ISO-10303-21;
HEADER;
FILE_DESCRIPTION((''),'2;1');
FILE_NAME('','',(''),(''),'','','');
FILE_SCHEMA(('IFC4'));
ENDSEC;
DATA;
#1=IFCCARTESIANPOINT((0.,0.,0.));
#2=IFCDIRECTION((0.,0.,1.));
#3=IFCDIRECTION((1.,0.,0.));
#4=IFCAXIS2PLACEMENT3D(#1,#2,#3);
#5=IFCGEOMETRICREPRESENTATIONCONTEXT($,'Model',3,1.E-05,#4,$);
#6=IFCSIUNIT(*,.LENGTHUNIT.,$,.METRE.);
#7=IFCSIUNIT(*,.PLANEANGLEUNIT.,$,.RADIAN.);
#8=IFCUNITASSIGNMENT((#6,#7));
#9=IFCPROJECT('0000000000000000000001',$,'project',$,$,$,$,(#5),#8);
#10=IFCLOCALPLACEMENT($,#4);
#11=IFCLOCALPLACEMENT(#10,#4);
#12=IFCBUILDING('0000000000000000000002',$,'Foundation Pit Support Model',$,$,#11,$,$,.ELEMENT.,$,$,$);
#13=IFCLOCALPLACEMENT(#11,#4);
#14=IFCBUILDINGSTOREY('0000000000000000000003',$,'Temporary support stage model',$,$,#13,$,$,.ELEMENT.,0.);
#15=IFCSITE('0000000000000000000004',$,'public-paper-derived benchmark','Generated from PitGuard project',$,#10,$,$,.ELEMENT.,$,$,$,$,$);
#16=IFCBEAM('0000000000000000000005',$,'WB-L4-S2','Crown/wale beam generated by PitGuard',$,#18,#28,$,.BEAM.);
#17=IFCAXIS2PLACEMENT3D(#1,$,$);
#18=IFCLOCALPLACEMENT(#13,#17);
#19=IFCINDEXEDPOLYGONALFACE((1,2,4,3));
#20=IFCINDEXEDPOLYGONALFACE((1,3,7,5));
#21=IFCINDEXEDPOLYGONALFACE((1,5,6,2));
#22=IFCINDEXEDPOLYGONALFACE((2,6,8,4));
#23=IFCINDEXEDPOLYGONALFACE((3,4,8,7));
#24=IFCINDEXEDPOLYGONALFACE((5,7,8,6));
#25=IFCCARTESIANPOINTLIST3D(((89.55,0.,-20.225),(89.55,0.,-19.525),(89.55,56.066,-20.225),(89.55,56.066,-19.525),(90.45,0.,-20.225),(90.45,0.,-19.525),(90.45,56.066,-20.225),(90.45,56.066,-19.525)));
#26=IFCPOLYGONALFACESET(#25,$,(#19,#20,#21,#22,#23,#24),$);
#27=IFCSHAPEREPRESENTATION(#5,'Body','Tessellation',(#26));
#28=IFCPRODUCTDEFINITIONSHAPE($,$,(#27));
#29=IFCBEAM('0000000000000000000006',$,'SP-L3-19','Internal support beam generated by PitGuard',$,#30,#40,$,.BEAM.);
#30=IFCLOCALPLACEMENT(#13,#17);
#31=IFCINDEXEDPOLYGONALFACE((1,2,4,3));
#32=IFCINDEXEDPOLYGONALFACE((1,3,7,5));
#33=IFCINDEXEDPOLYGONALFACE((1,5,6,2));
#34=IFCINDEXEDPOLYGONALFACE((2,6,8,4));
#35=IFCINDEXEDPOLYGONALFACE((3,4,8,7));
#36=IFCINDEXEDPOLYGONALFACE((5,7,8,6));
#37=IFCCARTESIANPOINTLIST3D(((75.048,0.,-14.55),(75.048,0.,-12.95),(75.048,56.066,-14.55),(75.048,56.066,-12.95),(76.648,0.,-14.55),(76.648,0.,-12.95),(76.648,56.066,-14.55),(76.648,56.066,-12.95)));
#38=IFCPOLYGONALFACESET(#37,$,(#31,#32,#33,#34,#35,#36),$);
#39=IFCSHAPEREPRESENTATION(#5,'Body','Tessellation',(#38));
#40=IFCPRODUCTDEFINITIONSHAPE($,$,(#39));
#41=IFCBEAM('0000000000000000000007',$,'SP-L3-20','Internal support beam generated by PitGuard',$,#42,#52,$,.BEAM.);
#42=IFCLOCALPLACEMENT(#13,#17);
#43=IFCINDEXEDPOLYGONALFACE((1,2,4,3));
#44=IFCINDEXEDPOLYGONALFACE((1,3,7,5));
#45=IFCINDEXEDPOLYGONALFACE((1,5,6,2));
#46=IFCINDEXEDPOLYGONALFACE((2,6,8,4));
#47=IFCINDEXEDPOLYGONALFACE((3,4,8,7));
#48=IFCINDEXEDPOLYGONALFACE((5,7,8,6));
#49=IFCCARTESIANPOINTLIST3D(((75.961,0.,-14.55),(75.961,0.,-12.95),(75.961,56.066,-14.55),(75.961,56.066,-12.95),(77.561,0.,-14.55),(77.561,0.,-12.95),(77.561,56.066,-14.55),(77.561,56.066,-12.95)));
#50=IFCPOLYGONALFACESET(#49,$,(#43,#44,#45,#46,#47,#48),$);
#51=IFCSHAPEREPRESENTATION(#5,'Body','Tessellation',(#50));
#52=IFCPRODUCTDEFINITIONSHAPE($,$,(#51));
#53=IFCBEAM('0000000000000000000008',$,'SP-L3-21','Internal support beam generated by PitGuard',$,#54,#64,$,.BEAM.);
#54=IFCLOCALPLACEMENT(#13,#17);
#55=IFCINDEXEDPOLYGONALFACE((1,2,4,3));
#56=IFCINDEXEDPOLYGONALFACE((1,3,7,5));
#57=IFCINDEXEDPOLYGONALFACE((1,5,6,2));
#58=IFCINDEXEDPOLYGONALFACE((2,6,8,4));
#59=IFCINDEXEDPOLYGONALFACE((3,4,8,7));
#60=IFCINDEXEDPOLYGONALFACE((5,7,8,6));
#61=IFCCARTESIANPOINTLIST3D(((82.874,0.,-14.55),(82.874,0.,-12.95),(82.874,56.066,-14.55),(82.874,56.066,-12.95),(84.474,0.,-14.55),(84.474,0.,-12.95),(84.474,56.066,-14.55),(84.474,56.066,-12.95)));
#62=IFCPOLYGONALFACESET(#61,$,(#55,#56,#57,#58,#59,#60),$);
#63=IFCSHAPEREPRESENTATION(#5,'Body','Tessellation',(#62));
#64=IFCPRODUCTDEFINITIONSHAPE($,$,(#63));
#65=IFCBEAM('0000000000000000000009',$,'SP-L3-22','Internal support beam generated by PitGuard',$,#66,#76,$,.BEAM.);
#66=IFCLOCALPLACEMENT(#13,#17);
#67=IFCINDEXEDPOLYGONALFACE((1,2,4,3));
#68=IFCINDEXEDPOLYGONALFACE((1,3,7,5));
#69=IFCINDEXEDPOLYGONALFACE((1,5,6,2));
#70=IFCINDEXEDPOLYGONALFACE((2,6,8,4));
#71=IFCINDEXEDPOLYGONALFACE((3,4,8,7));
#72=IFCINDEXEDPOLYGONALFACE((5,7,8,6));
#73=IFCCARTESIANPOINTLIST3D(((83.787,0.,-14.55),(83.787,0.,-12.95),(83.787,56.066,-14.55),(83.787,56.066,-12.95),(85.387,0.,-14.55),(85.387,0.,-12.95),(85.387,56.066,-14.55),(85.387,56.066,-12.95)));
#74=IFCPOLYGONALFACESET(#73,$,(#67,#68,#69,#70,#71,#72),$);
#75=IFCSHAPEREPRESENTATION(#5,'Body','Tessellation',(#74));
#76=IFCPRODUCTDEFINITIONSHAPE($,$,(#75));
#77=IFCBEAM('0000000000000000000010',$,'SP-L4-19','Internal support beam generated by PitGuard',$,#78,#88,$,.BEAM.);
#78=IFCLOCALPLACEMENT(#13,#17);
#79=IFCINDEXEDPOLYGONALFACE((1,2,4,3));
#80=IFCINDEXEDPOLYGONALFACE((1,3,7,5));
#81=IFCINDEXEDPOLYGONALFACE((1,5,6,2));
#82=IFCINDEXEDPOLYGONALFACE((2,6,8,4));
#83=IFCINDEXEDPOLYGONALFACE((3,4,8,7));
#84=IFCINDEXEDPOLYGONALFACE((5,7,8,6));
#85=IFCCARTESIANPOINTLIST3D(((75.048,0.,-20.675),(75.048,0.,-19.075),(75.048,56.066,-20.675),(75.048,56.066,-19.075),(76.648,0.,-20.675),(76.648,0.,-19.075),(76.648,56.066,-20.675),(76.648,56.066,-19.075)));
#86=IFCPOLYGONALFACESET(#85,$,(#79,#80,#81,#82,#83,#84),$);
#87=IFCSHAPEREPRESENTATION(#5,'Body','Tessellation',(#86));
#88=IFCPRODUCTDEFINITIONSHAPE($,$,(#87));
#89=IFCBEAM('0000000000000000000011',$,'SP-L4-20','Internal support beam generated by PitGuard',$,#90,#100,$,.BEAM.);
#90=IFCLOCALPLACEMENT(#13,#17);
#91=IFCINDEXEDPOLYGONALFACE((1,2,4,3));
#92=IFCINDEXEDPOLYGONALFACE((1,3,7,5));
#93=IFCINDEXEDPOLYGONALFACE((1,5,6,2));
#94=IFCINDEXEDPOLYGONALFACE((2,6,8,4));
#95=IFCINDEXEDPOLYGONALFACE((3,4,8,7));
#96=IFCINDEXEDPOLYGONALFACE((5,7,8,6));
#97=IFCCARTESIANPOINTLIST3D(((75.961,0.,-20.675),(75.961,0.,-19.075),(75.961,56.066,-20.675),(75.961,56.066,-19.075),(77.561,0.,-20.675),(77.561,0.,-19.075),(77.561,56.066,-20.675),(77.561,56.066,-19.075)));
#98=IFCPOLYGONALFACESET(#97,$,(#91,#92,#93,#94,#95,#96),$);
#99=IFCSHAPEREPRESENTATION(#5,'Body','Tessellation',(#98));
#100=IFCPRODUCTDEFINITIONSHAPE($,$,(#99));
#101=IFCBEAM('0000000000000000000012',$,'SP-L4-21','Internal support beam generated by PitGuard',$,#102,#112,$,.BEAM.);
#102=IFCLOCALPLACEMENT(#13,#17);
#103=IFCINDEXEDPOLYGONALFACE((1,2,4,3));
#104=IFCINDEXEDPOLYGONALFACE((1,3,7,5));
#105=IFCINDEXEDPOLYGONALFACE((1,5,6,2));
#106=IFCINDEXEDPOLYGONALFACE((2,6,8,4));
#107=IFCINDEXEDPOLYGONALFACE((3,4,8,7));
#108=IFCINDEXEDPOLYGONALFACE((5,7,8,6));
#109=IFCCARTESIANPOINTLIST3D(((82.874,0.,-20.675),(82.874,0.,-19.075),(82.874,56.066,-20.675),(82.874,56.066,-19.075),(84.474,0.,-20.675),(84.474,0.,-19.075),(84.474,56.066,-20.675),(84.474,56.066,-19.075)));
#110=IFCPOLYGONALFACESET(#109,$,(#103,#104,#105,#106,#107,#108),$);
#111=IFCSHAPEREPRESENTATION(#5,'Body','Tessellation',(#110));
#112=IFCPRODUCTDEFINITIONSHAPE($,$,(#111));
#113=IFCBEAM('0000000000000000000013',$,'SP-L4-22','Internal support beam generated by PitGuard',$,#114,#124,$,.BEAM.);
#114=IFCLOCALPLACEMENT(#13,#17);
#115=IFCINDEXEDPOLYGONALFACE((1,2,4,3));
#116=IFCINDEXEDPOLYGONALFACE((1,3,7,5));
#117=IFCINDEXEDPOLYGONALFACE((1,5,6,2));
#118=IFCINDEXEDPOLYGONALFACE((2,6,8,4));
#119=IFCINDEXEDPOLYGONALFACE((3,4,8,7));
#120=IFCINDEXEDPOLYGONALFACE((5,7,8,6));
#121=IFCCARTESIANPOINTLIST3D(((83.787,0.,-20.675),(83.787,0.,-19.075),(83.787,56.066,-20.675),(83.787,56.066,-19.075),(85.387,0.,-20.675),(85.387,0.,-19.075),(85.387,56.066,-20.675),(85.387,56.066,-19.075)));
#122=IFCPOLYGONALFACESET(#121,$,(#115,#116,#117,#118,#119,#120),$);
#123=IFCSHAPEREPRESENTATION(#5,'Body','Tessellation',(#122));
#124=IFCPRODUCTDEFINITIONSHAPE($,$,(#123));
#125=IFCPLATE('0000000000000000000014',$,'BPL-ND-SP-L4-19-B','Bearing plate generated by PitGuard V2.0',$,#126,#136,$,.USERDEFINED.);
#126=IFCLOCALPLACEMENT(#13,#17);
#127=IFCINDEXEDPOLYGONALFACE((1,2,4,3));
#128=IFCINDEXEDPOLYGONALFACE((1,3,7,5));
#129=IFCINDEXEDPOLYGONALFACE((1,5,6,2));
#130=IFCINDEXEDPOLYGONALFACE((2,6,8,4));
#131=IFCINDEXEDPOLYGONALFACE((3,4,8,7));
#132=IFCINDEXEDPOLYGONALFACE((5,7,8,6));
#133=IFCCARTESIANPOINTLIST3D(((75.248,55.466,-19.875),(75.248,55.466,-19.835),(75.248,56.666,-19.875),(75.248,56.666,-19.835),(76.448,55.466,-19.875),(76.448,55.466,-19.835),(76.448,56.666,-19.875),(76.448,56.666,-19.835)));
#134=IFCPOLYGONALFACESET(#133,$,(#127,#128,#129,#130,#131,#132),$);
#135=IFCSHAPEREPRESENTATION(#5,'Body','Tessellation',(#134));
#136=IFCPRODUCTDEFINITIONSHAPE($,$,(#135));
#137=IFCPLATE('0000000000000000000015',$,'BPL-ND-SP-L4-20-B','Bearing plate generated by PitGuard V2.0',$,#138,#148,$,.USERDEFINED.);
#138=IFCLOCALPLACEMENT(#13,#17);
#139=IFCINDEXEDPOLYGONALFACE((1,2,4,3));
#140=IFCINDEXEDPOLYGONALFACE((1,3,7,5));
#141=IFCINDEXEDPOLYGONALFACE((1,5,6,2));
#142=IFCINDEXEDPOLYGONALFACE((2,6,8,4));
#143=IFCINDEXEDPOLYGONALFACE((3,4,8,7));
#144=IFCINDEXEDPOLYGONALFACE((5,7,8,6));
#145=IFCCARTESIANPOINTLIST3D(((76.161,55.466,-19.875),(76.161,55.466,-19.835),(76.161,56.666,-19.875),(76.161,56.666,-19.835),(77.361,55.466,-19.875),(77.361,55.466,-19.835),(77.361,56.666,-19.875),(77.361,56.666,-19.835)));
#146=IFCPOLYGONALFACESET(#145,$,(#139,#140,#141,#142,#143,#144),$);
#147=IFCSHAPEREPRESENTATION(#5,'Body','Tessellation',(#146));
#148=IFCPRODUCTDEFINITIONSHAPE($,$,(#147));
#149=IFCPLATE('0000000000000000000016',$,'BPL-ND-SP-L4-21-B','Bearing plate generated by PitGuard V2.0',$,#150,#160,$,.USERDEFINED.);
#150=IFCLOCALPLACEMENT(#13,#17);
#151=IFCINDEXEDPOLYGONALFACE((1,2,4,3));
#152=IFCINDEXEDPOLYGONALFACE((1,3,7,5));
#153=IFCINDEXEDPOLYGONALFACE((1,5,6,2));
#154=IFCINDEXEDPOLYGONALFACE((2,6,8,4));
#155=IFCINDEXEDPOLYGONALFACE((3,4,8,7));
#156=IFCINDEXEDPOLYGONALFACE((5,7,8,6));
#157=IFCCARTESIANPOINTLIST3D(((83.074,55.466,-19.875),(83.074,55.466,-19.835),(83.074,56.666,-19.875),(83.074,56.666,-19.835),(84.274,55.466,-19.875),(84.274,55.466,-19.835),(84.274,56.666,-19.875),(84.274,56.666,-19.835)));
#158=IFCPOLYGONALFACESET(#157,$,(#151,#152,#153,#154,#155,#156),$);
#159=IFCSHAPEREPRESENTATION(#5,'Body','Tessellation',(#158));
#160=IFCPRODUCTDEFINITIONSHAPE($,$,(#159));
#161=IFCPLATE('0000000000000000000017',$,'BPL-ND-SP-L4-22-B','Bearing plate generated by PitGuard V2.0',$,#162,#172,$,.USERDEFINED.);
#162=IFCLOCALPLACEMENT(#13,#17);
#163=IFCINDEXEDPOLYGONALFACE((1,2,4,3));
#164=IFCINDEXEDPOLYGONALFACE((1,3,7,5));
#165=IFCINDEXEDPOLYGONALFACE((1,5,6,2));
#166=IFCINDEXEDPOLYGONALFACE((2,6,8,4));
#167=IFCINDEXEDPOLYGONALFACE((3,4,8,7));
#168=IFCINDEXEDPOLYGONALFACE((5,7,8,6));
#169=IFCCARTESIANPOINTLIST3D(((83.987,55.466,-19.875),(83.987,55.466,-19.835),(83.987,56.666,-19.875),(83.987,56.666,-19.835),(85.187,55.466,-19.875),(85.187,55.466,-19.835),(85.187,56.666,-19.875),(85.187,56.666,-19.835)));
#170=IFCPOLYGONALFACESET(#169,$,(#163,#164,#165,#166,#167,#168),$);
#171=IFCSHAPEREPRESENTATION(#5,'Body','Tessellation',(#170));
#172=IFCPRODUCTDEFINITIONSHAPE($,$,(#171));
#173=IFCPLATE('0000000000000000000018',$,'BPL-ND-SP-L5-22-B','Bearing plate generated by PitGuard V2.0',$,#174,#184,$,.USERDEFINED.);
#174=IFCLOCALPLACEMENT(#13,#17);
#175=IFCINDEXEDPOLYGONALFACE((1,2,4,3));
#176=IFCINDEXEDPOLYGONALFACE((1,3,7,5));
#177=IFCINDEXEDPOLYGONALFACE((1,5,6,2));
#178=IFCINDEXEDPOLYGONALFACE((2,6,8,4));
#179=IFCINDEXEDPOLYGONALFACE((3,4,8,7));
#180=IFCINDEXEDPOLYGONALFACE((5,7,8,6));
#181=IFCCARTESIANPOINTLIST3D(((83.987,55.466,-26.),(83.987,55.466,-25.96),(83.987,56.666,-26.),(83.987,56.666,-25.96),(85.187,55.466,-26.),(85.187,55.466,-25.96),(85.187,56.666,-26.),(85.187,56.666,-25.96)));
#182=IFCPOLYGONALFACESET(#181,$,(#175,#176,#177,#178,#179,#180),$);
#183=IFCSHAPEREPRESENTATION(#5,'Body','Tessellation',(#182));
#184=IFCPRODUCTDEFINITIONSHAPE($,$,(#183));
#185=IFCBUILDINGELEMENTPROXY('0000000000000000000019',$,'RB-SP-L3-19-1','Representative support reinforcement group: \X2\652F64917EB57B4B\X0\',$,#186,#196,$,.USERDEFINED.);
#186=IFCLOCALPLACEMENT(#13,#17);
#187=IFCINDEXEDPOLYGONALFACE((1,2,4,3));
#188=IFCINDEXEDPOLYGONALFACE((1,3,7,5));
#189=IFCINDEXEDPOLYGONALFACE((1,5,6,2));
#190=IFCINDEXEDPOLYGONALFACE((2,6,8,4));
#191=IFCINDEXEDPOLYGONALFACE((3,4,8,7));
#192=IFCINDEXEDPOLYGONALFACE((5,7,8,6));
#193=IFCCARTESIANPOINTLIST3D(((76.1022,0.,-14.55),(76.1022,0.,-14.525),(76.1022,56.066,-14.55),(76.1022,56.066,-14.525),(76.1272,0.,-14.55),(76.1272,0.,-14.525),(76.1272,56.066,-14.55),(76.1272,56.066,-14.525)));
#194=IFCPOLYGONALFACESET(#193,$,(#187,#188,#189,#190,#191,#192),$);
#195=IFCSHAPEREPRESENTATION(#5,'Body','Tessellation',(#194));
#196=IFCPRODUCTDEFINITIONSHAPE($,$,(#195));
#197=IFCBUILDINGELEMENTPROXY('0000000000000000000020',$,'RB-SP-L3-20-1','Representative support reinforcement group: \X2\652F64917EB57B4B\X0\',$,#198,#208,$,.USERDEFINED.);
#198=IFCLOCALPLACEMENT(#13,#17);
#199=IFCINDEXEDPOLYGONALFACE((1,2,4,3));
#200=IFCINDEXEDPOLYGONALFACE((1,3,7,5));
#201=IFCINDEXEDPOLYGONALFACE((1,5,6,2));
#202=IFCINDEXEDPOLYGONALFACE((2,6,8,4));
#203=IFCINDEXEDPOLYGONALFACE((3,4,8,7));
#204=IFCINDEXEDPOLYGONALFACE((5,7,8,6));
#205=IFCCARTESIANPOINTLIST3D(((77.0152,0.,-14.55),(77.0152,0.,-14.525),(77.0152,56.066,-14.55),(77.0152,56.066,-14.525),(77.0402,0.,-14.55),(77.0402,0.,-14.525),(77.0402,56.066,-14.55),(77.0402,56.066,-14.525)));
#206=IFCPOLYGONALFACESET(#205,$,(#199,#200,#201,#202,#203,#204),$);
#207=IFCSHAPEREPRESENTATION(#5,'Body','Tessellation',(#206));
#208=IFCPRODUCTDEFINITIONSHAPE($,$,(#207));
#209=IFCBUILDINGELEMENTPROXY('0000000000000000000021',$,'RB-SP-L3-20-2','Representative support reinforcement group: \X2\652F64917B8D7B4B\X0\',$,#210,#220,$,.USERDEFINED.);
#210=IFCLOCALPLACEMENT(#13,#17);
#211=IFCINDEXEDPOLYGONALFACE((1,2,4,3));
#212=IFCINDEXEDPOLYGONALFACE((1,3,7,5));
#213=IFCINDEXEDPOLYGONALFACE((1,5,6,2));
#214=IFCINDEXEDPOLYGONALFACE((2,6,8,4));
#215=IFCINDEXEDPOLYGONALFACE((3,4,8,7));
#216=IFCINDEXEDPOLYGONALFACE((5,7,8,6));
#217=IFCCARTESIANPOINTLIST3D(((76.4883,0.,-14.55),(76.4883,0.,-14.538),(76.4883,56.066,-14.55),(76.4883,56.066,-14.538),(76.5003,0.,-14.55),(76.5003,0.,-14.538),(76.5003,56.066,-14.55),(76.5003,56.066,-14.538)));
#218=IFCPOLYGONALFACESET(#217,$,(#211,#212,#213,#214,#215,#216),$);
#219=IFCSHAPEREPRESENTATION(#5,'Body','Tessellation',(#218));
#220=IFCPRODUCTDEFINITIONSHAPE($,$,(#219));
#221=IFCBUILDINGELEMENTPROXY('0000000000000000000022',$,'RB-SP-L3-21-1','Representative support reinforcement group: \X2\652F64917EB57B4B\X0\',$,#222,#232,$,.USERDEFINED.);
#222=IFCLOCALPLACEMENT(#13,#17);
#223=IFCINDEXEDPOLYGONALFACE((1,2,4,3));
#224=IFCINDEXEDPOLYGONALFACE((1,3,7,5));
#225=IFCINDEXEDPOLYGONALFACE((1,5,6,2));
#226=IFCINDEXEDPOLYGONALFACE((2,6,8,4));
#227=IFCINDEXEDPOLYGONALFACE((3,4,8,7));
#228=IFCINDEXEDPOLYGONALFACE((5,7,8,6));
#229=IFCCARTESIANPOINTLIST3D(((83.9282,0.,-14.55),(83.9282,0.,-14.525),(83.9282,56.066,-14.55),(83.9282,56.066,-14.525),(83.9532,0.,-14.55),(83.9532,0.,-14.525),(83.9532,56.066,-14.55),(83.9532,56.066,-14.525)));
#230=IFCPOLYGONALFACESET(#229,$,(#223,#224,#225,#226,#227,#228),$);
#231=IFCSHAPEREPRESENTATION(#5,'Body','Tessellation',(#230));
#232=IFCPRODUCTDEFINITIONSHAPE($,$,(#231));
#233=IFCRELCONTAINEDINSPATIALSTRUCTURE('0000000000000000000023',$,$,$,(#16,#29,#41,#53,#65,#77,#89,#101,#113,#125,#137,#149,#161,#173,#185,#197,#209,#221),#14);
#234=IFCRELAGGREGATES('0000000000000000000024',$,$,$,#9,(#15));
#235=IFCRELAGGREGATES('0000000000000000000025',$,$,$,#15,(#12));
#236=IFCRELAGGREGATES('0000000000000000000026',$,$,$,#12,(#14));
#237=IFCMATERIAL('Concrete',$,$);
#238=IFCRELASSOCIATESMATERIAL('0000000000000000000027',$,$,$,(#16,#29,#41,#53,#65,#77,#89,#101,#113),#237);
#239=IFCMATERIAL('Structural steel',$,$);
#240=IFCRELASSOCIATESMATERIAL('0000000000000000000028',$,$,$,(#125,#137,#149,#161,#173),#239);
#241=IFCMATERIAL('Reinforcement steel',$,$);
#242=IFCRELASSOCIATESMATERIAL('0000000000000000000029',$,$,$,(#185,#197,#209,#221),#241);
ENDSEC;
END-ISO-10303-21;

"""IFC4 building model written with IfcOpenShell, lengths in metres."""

from ifc_helpers import new_model, si_unit, frame, origin_with_axes, origin_2d, place, context, project, spatial, rectangle, extrude, material, element, save


model = new_model("IFC4")

# Units and contexts
model_context = context("Model", 3, precision=1e-05, world=origin_with_axes())
ifc_project = project(units=[si_unit("LENGTHUNIT", "METRE"), si_unit("PLANEANGLEUNIT", "RADIAN")], contexts=[model_context])

# Site, building, storey
site_placement = place(None, origin_with_axes())
site = spatial("IfcSite", under=ifc_project, at=site_placement, Name="public-paper-derived benchmark", Description="Generated from PitGuard project", CompositionType="ELEMENT")
building_placement = place(site_placement, origin_with_axes())
building = spatial("IfcBuilding", under=site, at=building_placement, Name="Foundation Pit Support Model", CompositionType="ELEMENT")
storey_placement = place(building_placement, origin_with_axes())
storey = spatial("IfcBuildingStorey", under=building, at=storey_placement, Name="Temporary support stage model", CompositionType="ELEMENT", Elevation=0.0)

# Beams
ifc_material_1 = material(Name="Concrete")
beam_placement = place(storey_placement, frame((90.0, 28.033, -20.225), z_axis=(0.0, 0.0, 1.0), x_axis=(0.0, 1.0, 0.0)))
element("IfcBeam", 1, at=beam_placement, inside=storey, material=ifc_material_1, Name="WB-L4-S2", Description="Crown/wale beam generated by PitGuard", PredefinedType="BEAM", context=model_context, shape_type="SweptSolid", body=[
    extrude(rectangle(XDim=56.066, YDim=0.9, at=origin_2d()), origin_with_axes(), (0.0, 0.0, 1.0), 0.7),
])
for number, where, z_axis, x_axis, name in (
    (2, (75.848, 28.033, -14.55), (0.0, 0.0, 1.0), (0.0, 1.0, 0.0), "SP-L3-19"),
    (3, (76.761, 28.033, -14.55), (0.0, 0.0, 1.0), (0.0, 1.0, 0.0), "SP-L3-20"),
    (4, (83.674, 28.033, -14.55), (0.0, 0.0, 1.0), (0.0, 1.0, 0.0), "SP-L3-21"),
    (5, (84.587, 28.033, -14.55), (0.0, 0.0, 1.0), (0.0, 1.0, 0.0), "SP-L3-22"),
    (6, (75.848, 28.033, -20.675), (0.0, 0.0, 1.0), (0.0, 1.0, 0.0), "SP-L4-19"),
    (7, (76.761, 28.033, -20.675), (0.0, 0.0, 1.0), (0.0, 1.0, 0.0), "SP-L4-20"),
    (8, (83.674, 28.033, -20.675), (0.0, 0.0, 1.0), (0.0, 1.0, 0.0), "SP-L4-21"),
    (9, (84.587, 28.033, -20.675), (0.0, 0.0, 1.0), (0.0, 1.0, 0.0), "SP-L4-22"),
):
    element("IfcBeam", number, at=place(storey_placement, frame(where, z_axis=z_axis, x_axis=x_axis)), inside=storey, material=ifc_material_1, Name=name, Description="Internal support beam generated by PitGuard", PredefinedType="BEAM", context=model_context, shape_type="SweptSolid", body=[
        extrude(rectangle(XDim=56.066, YDim=1.6, at=origin_2d()), origin_with_axes(), (0.0, 0.0, 1.0), 1.6),
    ])

# Plates
ifc_material_2 = material(Name="Structural steel")
for number, where, z_axis, x_axis, name in (
    (10, (75.848, 56.066, -19.875), (0.0, 0.0, 1.0), (1.0, 0.0, 0.0), "BPL-ND-SP-L4-19-B"),
    (11, (76.761, 56.066, -19.875), (0.0, 0.0, 1.0), (1.0, 0.0, 0.0), "BPL-ND-SP-L4-20-B"),
    (12, (83.674, 56.066, -19.875), (0.0, 0.0, 1.0), (1.0, 0.0, 0.0), "BPL-ND-SP-L4-21-B"),
    (13, (84.587, 56.066, -19.875), (0.0, 0.0, 1.0), (1.0, 0.0, 0.0), "BPL-ND-SP-L4-22-B"),
    (14, (84.587, 56.066, -26.0), (0.0, 0.0, 1.0), (1.0, 0.0, 0.0), "BPL-ND-SP-L5-22-B"),
):
    element("IfcPlate", number, at=place(storey_placement, frame(where, z_axis=z_axis, x_axis=x_axis)), inside=storey, material=ifc_material_2, Name=name, Description="Bearing plate generated by PitGuard V2.0", PredefinedType="USERDEFINED", context=model_context, shape_type="SweptSolid", body=[
        extrude(rectangle(XDim=1.2, YDim=1.2, at=origin_2d()), origin_with_axes(), (0.0, 0.0, 1.0), 0.04),
    ])

# Building element proxies
ifc_material_3 = material(Name="Reinforcement steel")
for number, where, z_axis, x_axis, name in (
    (15, (76.1147, 28.033, -14.55), (0.0, 0.0, 1.0), (0.0, 1.0, 0.0), "RB-SP-L3-19-1"),
    (16, (77.0277, 28.033, -14.55), (0.0, 0.0, 1.0), (0.0, 1.0, 0.0), "RB-SP-L3-20-1"),
):
    element("IfcBuildingElementProxy", number, at=place(storey_placement, frame(where, z_axis=z_axis, x_axis=x_axis)), inside=storey, material=ifc_material_3, Name=name, Description="Representative support reinforcement group: 支撑纵筋", PredefinedType="USERDEFINED", context=model_context, shape_type="SweptSolid", body=[
        extrude(rectangle(XDim=56.066, YDim=0.025, at=origin_2d()), origin_with_axes(), (0.0, 0.0, 1.0), 0.025),
    ])
proxy_1_placement = place(storey_placement, frame((76.4943, 28.033, -14.55), z_axis=(0.0, 0.0, 1.0), x_axis=(0.0, 1.0, 0.0)))
element("IfcBuildingElementProxy", 17, at=proxy_1_placement, inside=storey, material=ifc_material_3, Name="RB-SP-L3-20-2", Description="Representative support reinforcement group: 支撑箍筋", PredefinedType="USERDEFINED", context=model_context, shape_type="SweptSolid", body=[
    extrude(rectangle(XDim=56.066, YDim=0.012, at=origin_2d()), origin_with_axes(), (0.0, 0.0, 1.0), 0.012),
])
proxy_2_placement = place(storey_placement, frame((83.9407, 28.033, -14.55), z_axis=(0.0, 0.0, 1.0), x_axis=(0.0, 1.0, 0.0)))
element("IfcBuildingElementProxy", 18, at=proxy_2_placement, inside=storey, material=ifc_material_3, Name="RB-SP-L3-21-1", Description="Representative support reinforcement group: 支撑纵筋", PredefinedType="USERDEFINED", context=model_context, shape_type="SweptSolid", body=[
    extrude(rectangle(XDim=56.066, YDim=0.025, at=origin_2d()), origin_with_axes(), (0.0, 0.0, 1.0), 0.025),
])

save(model, "model.ifc")
